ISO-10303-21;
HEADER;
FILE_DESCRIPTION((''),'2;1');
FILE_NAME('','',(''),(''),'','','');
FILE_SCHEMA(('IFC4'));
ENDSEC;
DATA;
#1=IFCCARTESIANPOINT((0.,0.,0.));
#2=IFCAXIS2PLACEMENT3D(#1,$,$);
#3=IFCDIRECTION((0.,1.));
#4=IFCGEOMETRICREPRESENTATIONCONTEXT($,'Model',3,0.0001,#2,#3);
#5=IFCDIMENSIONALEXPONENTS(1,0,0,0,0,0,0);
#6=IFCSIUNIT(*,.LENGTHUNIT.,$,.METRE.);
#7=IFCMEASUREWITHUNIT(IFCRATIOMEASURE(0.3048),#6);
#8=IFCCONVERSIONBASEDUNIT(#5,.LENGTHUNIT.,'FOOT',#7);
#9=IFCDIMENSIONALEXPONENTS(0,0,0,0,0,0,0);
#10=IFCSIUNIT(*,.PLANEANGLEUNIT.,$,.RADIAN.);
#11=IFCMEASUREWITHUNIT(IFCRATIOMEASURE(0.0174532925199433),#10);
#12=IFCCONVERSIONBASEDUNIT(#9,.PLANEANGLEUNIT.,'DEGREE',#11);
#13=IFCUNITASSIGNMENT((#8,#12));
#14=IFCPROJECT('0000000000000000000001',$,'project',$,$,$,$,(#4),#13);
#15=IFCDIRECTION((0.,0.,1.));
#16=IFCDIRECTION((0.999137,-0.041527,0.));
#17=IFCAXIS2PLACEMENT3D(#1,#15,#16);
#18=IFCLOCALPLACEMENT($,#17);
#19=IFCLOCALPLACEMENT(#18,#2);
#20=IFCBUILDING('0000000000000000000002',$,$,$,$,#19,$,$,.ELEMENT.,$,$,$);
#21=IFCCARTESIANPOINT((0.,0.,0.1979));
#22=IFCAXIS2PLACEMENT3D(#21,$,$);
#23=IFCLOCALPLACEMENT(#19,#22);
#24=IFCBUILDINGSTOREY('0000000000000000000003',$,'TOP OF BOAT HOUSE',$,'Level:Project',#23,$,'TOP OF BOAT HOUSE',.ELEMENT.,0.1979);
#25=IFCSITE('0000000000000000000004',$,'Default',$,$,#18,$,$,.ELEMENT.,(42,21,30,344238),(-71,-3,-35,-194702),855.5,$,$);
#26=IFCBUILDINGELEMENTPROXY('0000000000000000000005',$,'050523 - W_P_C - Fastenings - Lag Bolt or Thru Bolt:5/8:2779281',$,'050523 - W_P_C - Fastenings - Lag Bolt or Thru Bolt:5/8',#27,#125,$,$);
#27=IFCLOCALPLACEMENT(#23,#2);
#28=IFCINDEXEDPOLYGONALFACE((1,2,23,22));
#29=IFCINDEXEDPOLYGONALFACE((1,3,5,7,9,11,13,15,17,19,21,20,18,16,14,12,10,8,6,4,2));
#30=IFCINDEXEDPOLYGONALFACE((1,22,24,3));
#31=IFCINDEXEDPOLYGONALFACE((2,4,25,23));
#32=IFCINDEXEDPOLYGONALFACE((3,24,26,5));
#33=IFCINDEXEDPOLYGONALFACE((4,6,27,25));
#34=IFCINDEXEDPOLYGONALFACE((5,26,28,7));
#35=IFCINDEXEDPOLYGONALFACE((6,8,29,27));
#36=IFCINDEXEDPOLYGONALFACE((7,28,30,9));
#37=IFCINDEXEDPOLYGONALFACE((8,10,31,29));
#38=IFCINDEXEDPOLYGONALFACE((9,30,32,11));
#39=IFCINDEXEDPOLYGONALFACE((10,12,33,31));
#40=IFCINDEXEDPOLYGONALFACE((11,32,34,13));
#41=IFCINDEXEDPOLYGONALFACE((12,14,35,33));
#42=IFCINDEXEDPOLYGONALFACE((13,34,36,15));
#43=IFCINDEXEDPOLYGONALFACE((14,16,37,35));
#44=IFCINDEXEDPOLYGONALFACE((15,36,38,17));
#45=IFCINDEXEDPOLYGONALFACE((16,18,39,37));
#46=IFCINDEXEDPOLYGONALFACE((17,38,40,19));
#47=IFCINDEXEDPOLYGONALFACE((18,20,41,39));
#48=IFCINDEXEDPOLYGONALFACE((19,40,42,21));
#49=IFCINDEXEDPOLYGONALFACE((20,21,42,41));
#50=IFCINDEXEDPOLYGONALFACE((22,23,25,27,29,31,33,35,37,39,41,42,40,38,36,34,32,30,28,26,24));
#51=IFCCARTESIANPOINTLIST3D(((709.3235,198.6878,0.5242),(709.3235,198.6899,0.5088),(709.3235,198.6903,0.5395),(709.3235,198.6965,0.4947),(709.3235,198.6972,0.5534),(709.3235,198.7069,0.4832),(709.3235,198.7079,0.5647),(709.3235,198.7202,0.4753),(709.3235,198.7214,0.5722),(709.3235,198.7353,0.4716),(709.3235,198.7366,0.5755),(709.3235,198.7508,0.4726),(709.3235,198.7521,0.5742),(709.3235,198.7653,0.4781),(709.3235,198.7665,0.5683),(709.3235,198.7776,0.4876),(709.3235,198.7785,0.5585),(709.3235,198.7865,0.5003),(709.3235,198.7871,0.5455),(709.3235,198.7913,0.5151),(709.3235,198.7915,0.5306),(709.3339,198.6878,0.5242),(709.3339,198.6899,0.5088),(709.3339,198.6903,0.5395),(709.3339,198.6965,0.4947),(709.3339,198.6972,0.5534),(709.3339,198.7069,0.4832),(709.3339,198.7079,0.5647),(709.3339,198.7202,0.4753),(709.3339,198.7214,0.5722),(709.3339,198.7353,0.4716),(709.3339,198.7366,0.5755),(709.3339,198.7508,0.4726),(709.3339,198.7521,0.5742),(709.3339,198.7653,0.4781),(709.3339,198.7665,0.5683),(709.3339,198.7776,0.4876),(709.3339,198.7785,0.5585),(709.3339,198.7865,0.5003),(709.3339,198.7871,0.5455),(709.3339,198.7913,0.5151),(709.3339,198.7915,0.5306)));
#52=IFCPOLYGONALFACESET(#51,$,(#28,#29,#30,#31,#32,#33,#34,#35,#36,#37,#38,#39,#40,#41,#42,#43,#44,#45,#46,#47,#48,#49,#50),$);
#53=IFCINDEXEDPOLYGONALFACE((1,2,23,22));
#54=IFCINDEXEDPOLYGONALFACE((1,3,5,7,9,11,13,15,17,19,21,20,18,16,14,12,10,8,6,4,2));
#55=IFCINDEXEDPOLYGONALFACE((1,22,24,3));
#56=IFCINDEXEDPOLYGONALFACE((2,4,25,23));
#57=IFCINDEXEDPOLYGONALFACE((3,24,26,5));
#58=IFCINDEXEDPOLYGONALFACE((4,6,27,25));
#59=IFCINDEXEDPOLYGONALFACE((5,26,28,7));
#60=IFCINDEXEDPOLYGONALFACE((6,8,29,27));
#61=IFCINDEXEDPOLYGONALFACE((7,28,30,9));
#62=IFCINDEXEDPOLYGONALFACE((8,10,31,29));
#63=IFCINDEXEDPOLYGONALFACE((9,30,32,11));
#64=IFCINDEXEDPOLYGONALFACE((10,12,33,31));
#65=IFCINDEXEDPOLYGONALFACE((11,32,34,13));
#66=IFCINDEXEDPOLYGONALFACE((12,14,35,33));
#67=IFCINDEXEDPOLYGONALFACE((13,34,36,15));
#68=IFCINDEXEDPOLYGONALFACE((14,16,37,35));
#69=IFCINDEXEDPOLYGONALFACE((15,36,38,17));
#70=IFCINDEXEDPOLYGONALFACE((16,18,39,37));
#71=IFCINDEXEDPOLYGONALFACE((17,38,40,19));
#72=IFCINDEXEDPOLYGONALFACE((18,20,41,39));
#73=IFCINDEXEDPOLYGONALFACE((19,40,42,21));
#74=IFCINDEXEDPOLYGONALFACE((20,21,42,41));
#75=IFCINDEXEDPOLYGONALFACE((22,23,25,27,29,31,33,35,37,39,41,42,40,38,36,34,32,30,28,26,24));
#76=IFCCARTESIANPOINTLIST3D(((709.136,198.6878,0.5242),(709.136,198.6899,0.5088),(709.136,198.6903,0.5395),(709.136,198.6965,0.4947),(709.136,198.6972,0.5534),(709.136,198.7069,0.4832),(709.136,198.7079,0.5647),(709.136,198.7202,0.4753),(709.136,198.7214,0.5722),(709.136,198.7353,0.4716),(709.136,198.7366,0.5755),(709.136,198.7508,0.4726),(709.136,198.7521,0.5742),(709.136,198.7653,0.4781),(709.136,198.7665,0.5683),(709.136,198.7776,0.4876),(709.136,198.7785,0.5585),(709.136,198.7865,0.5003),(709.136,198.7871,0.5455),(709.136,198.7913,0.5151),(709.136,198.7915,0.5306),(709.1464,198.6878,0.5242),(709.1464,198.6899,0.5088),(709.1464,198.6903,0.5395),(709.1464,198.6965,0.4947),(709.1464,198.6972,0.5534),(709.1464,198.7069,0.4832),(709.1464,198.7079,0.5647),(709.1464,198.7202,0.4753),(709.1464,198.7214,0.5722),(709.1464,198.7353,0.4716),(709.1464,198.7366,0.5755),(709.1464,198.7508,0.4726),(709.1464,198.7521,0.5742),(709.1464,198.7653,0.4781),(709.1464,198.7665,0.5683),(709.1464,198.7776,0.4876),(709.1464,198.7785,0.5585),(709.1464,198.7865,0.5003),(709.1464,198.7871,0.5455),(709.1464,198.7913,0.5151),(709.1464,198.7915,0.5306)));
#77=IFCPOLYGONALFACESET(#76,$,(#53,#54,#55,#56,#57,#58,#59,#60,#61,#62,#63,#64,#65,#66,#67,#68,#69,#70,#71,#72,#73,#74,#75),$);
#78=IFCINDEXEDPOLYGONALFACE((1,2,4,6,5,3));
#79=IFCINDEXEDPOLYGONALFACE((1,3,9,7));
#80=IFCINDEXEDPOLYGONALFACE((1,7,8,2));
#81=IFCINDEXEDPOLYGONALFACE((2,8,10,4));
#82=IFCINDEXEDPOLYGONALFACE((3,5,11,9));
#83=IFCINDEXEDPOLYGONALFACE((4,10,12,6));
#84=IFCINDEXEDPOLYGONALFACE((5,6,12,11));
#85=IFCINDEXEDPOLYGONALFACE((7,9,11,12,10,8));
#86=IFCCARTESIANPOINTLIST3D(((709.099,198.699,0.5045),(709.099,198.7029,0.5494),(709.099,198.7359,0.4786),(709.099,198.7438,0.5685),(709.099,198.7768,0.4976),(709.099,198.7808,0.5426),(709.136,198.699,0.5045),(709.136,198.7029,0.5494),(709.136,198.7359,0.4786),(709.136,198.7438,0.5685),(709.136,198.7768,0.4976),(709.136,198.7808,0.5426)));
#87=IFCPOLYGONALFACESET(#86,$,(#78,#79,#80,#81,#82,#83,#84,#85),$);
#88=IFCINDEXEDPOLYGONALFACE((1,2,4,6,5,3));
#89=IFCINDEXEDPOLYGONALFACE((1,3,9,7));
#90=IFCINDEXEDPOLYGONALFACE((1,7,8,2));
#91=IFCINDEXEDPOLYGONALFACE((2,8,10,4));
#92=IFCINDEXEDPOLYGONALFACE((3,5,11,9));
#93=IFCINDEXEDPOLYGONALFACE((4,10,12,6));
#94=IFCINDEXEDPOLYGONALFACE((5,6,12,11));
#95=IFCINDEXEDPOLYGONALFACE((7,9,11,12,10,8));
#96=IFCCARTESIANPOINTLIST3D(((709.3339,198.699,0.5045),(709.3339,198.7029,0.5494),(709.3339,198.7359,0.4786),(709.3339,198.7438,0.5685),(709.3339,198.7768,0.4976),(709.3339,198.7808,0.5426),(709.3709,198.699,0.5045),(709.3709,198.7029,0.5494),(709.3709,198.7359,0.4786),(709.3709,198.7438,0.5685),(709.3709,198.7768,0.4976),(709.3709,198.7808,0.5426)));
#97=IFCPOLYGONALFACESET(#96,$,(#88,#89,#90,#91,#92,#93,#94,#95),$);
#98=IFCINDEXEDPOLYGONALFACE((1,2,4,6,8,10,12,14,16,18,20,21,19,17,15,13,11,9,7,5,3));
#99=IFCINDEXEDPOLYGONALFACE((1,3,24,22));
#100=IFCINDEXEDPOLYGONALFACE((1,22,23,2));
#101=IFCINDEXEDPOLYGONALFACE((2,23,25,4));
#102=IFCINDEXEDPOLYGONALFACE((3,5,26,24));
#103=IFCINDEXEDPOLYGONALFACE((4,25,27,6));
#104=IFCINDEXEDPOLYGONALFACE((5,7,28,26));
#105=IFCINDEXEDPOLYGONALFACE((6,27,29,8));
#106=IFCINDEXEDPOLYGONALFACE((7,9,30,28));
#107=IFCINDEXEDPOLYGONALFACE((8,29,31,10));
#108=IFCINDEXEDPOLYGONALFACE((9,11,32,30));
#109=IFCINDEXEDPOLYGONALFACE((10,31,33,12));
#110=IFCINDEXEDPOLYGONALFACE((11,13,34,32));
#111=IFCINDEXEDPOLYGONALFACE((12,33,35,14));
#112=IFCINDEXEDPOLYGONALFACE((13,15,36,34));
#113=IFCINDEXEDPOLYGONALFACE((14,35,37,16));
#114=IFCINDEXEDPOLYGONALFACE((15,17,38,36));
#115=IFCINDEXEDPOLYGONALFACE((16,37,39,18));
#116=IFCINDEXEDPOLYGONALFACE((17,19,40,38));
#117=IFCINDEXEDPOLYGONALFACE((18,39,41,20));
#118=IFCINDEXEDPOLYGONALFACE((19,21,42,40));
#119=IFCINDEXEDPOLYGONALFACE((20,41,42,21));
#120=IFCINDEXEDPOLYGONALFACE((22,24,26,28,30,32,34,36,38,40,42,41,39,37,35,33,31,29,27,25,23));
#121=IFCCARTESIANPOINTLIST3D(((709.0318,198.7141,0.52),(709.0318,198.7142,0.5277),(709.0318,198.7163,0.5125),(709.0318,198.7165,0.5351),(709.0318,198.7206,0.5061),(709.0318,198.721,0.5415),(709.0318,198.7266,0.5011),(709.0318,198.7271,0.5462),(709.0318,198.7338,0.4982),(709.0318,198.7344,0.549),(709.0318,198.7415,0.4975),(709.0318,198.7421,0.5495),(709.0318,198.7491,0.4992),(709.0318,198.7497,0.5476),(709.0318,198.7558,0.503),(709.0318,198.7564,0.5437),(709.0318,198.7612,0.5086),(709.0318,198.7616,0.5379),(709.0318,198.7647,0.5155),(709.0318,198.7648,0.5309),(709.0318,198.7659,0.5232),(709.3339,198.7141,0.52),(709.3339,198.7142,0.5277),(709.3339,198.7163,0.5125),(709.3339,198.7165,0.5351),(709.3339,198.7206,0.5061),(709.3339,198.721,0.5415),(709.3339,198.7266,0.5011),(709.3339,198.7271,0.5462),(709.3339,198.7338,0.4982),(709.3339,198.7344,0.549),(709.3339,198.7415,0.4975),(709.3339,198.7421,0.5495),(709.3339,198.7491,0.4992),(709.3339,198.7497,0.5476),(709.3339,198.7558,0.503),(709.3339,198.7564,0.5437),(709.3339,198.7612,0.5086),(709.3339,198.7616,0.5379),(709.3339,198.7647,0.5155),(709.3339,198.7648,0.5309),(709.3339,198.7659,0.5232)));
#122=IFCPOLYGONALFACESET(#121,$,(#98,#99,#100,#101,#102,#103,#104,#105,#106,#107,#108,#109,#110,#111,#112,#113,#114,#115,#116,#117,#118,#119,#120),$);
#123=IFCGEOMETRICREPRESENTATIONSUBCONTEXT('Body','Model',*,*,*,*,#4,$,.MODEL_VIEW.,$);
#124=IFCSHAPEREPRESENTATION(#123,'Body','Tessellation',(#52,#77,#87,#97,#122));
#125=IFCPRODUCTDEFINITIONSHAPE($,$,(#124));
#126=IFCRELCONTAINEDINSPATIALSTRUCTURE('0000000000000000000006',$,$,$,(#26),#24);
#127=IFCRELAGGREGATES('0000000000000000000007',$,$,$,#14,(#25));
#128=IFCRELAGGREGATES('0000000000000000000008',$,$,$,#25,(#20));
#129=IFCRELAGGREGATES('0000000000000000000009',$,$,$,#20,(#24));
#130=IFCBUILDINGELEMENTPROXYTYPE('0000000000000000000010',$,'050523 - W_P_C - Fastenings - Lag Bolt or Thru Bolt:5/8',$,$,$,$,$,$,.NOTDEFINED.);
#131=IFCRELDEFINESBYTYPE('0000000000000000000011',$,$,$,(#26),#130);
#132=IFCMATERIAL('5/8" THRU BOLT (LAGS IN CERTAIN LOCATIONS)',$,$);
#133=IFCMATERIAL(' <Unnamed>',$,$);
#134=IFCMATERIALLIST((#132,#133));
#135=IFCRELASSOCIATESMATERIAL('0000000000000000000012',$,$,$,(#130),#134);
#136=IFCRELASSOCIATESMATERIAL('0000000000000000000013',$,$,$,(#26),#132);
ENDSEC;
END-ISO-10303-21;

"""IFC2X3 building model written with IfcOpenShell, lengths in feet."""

from ifc_helpers import new_model, entity, si_unit, converted_unit, direction, frame, frame_2d, origin, place, context, subcontext, project, spatial, polyline, circle, outline, extrude, source, transform, mapped, material, material_list, type_object, type_shapes, element, save


model = new_model("IFC2X3")

# Units and contexts
model_context = context("Model", 3, precision=0.0001, world=origin(), true_north=direction((0.0, 1.0)))
body_context = subcontext(model_context, "Body", "Model", "MODEL_VIEW")
ifc_project = project(units=[converted_unit("LENGTHUNIT", "FOOT", entity("IfcRatioMeasure", 0.3048), si_unit("LENGTHUNIT", "METRE"), dimensions=[1, 0, 0, 0, 0, 0, 0]), converted_unit("PLANEANGLEUNIT", "DEGREE", entity("IfcRatioMeasure", 0.0174532925199433), si_unit("PLANEANGLEUNIT", "RADIAN"), dimensions=[0, 0, 0, 0, 0, 0, 0])], contexts=[model_context])

# Site, building, storey
site_placement = place(None, frame((0.0, 0.0, 0.0), z_axis=(0.0, 0.0, 1.0), x_axis=(0.999137, -0.041527, 0.0)))
site = spatial("IfcSite", under=ifc_project, at=site_placement, Name="Default", CompositionType="ELEMENT", RefLatitude=(42, 21, 30, 344238), RefLongitude=(-71, -3, -35, -194702), RefElevation=855.5)
building_placement = place(site_placement, origin())
building = spatial("IfcBuilding", under=site, at=building_placement, CompositionType="ELEMENT")
storey_placement = place(building_placement, frame((0.0, 0.0, 0.1979)))
storey = spatial("IfcBuildingStorey", under=building, at=storey_placement, Name="TOP OF BOAT HOUSE", ObjectType="Level:Project", LongName="TOP OF BOAT HOUSE", CompositionType="ELEMENT", Elevation=0.1979)

# Building element proxy
ifc_material_1 = material(Name="5/8\" THRU BOLT (LAGS IN CERTAIN LOCATIONS)")
ifc_material_2 = material(Name=" <Unnamed>")
ifc_material_list_1 = material_list([ifc_material_1, ifc_material_2])
building_element_proxy_type_1 = type_object("IfcBuildingElementProxyType", Name="050523 - W_P_C - Fastenings - Lag Bolt or Thru Bolt:5/8", PredefinedType="NOTDEFINED", material=ifc_material_list_1)
shared_shape_1 = source(origin(), body_context, "Body", "SweptSolid", [
    extrude(circle(Radius=0.0521, at=frame_2d((0.0, 0.0), x_axis=(1.0, 0.0))), frame((0.0, 0.0, 0.0), z_axis=(0.0, 0.0, 1.0), x_axis=(0.0, -1.0, 0.0)), (0.0, 0.0, 1.0), 0.0104),
    extrude(circle(Radius=0.0521, at=frame_2d((0.0, 0.0), x_axis=(1.0, 0.0))), frame((0.0, 0.0, -0.1875), z_axis=(0.0, 0.0, 1.0), x_axis=(0.0, -1.0, 0.0)), (0.0, 0.0, 1.0), 0.0104),
    extrude(outline(polyline([(-0.0226, -0.0391), (0.0226, -0.0391), (0.0451, 0.0), (0.0226, 0.0391), (-0.0226, 0.0391), (-0.0451, 0.0), (-0.0226, -0.0391)])), frame((0.0, 0.0, -0.2245), z_axis=(0.0, 0.0, 1.0), x_axis=(0.866025, -0.5, 0.0)), (0.0, 0.0, 1.0), 0.037),
    extrude(outline(polyline([(-0.0226, -0.0391), (0.0226, -0.0391), (0.0451, 0.0), (0.0226, 0.0391), (-0.0226, 0.0391), (-0.0451, 0.0), (-0.0226, -0.0391)])), frame((0.0, 0.0, 0.0104), z_axis=(0.0, 0.0, 1.0), x_axis=(0.0, -1.0, 0.0)), (0.0, 0.0, 1.0), 0.037),
    extrude(circle(Radius=0.026, at=frame_2d((0.0, 0.0), x_axis=(1.0, 0.0))), frame((0.0, 0.0, -0.2917), z_axis=(0.0, 0.0, 1.0), x_axis=(0.0, 1.0, 0.0)), (0.0, 0.0, 1.0), 0.3021),
])
type_shapes(building_element_proxy_type_1, [shared_shape_1])
for number, where, z_axis, x_axis, name in (
    (1, (709.3235, 198.7399, 0.5235), (1.0, 0.0, 0.0), (0.0, 0.996195, -0.087156), "050523 - W_P_C - Fastenings - Lag Bolt or Thru Bolt:5/8:2779281"),
):
    element("IfcBuildingElementProxy", number, at=place(storey_placement, frame(where, z_axis=z_axis, x_axis=x_axis)), inside=storey, type_object=building_element_proxy_type_1, material=ifc_material_1, Name=name, ObjectType="050523 - W_P_C - Fastenings - Lag Bolt or Thru Bolt:5/8", context=body_context, shape_type="MappedRepresentation", body=[
        mapped(shared_shape_1, transform((0.0, 0.0, 0.0), scale=1.0)),
    ])

save(model, "model.ifc")
